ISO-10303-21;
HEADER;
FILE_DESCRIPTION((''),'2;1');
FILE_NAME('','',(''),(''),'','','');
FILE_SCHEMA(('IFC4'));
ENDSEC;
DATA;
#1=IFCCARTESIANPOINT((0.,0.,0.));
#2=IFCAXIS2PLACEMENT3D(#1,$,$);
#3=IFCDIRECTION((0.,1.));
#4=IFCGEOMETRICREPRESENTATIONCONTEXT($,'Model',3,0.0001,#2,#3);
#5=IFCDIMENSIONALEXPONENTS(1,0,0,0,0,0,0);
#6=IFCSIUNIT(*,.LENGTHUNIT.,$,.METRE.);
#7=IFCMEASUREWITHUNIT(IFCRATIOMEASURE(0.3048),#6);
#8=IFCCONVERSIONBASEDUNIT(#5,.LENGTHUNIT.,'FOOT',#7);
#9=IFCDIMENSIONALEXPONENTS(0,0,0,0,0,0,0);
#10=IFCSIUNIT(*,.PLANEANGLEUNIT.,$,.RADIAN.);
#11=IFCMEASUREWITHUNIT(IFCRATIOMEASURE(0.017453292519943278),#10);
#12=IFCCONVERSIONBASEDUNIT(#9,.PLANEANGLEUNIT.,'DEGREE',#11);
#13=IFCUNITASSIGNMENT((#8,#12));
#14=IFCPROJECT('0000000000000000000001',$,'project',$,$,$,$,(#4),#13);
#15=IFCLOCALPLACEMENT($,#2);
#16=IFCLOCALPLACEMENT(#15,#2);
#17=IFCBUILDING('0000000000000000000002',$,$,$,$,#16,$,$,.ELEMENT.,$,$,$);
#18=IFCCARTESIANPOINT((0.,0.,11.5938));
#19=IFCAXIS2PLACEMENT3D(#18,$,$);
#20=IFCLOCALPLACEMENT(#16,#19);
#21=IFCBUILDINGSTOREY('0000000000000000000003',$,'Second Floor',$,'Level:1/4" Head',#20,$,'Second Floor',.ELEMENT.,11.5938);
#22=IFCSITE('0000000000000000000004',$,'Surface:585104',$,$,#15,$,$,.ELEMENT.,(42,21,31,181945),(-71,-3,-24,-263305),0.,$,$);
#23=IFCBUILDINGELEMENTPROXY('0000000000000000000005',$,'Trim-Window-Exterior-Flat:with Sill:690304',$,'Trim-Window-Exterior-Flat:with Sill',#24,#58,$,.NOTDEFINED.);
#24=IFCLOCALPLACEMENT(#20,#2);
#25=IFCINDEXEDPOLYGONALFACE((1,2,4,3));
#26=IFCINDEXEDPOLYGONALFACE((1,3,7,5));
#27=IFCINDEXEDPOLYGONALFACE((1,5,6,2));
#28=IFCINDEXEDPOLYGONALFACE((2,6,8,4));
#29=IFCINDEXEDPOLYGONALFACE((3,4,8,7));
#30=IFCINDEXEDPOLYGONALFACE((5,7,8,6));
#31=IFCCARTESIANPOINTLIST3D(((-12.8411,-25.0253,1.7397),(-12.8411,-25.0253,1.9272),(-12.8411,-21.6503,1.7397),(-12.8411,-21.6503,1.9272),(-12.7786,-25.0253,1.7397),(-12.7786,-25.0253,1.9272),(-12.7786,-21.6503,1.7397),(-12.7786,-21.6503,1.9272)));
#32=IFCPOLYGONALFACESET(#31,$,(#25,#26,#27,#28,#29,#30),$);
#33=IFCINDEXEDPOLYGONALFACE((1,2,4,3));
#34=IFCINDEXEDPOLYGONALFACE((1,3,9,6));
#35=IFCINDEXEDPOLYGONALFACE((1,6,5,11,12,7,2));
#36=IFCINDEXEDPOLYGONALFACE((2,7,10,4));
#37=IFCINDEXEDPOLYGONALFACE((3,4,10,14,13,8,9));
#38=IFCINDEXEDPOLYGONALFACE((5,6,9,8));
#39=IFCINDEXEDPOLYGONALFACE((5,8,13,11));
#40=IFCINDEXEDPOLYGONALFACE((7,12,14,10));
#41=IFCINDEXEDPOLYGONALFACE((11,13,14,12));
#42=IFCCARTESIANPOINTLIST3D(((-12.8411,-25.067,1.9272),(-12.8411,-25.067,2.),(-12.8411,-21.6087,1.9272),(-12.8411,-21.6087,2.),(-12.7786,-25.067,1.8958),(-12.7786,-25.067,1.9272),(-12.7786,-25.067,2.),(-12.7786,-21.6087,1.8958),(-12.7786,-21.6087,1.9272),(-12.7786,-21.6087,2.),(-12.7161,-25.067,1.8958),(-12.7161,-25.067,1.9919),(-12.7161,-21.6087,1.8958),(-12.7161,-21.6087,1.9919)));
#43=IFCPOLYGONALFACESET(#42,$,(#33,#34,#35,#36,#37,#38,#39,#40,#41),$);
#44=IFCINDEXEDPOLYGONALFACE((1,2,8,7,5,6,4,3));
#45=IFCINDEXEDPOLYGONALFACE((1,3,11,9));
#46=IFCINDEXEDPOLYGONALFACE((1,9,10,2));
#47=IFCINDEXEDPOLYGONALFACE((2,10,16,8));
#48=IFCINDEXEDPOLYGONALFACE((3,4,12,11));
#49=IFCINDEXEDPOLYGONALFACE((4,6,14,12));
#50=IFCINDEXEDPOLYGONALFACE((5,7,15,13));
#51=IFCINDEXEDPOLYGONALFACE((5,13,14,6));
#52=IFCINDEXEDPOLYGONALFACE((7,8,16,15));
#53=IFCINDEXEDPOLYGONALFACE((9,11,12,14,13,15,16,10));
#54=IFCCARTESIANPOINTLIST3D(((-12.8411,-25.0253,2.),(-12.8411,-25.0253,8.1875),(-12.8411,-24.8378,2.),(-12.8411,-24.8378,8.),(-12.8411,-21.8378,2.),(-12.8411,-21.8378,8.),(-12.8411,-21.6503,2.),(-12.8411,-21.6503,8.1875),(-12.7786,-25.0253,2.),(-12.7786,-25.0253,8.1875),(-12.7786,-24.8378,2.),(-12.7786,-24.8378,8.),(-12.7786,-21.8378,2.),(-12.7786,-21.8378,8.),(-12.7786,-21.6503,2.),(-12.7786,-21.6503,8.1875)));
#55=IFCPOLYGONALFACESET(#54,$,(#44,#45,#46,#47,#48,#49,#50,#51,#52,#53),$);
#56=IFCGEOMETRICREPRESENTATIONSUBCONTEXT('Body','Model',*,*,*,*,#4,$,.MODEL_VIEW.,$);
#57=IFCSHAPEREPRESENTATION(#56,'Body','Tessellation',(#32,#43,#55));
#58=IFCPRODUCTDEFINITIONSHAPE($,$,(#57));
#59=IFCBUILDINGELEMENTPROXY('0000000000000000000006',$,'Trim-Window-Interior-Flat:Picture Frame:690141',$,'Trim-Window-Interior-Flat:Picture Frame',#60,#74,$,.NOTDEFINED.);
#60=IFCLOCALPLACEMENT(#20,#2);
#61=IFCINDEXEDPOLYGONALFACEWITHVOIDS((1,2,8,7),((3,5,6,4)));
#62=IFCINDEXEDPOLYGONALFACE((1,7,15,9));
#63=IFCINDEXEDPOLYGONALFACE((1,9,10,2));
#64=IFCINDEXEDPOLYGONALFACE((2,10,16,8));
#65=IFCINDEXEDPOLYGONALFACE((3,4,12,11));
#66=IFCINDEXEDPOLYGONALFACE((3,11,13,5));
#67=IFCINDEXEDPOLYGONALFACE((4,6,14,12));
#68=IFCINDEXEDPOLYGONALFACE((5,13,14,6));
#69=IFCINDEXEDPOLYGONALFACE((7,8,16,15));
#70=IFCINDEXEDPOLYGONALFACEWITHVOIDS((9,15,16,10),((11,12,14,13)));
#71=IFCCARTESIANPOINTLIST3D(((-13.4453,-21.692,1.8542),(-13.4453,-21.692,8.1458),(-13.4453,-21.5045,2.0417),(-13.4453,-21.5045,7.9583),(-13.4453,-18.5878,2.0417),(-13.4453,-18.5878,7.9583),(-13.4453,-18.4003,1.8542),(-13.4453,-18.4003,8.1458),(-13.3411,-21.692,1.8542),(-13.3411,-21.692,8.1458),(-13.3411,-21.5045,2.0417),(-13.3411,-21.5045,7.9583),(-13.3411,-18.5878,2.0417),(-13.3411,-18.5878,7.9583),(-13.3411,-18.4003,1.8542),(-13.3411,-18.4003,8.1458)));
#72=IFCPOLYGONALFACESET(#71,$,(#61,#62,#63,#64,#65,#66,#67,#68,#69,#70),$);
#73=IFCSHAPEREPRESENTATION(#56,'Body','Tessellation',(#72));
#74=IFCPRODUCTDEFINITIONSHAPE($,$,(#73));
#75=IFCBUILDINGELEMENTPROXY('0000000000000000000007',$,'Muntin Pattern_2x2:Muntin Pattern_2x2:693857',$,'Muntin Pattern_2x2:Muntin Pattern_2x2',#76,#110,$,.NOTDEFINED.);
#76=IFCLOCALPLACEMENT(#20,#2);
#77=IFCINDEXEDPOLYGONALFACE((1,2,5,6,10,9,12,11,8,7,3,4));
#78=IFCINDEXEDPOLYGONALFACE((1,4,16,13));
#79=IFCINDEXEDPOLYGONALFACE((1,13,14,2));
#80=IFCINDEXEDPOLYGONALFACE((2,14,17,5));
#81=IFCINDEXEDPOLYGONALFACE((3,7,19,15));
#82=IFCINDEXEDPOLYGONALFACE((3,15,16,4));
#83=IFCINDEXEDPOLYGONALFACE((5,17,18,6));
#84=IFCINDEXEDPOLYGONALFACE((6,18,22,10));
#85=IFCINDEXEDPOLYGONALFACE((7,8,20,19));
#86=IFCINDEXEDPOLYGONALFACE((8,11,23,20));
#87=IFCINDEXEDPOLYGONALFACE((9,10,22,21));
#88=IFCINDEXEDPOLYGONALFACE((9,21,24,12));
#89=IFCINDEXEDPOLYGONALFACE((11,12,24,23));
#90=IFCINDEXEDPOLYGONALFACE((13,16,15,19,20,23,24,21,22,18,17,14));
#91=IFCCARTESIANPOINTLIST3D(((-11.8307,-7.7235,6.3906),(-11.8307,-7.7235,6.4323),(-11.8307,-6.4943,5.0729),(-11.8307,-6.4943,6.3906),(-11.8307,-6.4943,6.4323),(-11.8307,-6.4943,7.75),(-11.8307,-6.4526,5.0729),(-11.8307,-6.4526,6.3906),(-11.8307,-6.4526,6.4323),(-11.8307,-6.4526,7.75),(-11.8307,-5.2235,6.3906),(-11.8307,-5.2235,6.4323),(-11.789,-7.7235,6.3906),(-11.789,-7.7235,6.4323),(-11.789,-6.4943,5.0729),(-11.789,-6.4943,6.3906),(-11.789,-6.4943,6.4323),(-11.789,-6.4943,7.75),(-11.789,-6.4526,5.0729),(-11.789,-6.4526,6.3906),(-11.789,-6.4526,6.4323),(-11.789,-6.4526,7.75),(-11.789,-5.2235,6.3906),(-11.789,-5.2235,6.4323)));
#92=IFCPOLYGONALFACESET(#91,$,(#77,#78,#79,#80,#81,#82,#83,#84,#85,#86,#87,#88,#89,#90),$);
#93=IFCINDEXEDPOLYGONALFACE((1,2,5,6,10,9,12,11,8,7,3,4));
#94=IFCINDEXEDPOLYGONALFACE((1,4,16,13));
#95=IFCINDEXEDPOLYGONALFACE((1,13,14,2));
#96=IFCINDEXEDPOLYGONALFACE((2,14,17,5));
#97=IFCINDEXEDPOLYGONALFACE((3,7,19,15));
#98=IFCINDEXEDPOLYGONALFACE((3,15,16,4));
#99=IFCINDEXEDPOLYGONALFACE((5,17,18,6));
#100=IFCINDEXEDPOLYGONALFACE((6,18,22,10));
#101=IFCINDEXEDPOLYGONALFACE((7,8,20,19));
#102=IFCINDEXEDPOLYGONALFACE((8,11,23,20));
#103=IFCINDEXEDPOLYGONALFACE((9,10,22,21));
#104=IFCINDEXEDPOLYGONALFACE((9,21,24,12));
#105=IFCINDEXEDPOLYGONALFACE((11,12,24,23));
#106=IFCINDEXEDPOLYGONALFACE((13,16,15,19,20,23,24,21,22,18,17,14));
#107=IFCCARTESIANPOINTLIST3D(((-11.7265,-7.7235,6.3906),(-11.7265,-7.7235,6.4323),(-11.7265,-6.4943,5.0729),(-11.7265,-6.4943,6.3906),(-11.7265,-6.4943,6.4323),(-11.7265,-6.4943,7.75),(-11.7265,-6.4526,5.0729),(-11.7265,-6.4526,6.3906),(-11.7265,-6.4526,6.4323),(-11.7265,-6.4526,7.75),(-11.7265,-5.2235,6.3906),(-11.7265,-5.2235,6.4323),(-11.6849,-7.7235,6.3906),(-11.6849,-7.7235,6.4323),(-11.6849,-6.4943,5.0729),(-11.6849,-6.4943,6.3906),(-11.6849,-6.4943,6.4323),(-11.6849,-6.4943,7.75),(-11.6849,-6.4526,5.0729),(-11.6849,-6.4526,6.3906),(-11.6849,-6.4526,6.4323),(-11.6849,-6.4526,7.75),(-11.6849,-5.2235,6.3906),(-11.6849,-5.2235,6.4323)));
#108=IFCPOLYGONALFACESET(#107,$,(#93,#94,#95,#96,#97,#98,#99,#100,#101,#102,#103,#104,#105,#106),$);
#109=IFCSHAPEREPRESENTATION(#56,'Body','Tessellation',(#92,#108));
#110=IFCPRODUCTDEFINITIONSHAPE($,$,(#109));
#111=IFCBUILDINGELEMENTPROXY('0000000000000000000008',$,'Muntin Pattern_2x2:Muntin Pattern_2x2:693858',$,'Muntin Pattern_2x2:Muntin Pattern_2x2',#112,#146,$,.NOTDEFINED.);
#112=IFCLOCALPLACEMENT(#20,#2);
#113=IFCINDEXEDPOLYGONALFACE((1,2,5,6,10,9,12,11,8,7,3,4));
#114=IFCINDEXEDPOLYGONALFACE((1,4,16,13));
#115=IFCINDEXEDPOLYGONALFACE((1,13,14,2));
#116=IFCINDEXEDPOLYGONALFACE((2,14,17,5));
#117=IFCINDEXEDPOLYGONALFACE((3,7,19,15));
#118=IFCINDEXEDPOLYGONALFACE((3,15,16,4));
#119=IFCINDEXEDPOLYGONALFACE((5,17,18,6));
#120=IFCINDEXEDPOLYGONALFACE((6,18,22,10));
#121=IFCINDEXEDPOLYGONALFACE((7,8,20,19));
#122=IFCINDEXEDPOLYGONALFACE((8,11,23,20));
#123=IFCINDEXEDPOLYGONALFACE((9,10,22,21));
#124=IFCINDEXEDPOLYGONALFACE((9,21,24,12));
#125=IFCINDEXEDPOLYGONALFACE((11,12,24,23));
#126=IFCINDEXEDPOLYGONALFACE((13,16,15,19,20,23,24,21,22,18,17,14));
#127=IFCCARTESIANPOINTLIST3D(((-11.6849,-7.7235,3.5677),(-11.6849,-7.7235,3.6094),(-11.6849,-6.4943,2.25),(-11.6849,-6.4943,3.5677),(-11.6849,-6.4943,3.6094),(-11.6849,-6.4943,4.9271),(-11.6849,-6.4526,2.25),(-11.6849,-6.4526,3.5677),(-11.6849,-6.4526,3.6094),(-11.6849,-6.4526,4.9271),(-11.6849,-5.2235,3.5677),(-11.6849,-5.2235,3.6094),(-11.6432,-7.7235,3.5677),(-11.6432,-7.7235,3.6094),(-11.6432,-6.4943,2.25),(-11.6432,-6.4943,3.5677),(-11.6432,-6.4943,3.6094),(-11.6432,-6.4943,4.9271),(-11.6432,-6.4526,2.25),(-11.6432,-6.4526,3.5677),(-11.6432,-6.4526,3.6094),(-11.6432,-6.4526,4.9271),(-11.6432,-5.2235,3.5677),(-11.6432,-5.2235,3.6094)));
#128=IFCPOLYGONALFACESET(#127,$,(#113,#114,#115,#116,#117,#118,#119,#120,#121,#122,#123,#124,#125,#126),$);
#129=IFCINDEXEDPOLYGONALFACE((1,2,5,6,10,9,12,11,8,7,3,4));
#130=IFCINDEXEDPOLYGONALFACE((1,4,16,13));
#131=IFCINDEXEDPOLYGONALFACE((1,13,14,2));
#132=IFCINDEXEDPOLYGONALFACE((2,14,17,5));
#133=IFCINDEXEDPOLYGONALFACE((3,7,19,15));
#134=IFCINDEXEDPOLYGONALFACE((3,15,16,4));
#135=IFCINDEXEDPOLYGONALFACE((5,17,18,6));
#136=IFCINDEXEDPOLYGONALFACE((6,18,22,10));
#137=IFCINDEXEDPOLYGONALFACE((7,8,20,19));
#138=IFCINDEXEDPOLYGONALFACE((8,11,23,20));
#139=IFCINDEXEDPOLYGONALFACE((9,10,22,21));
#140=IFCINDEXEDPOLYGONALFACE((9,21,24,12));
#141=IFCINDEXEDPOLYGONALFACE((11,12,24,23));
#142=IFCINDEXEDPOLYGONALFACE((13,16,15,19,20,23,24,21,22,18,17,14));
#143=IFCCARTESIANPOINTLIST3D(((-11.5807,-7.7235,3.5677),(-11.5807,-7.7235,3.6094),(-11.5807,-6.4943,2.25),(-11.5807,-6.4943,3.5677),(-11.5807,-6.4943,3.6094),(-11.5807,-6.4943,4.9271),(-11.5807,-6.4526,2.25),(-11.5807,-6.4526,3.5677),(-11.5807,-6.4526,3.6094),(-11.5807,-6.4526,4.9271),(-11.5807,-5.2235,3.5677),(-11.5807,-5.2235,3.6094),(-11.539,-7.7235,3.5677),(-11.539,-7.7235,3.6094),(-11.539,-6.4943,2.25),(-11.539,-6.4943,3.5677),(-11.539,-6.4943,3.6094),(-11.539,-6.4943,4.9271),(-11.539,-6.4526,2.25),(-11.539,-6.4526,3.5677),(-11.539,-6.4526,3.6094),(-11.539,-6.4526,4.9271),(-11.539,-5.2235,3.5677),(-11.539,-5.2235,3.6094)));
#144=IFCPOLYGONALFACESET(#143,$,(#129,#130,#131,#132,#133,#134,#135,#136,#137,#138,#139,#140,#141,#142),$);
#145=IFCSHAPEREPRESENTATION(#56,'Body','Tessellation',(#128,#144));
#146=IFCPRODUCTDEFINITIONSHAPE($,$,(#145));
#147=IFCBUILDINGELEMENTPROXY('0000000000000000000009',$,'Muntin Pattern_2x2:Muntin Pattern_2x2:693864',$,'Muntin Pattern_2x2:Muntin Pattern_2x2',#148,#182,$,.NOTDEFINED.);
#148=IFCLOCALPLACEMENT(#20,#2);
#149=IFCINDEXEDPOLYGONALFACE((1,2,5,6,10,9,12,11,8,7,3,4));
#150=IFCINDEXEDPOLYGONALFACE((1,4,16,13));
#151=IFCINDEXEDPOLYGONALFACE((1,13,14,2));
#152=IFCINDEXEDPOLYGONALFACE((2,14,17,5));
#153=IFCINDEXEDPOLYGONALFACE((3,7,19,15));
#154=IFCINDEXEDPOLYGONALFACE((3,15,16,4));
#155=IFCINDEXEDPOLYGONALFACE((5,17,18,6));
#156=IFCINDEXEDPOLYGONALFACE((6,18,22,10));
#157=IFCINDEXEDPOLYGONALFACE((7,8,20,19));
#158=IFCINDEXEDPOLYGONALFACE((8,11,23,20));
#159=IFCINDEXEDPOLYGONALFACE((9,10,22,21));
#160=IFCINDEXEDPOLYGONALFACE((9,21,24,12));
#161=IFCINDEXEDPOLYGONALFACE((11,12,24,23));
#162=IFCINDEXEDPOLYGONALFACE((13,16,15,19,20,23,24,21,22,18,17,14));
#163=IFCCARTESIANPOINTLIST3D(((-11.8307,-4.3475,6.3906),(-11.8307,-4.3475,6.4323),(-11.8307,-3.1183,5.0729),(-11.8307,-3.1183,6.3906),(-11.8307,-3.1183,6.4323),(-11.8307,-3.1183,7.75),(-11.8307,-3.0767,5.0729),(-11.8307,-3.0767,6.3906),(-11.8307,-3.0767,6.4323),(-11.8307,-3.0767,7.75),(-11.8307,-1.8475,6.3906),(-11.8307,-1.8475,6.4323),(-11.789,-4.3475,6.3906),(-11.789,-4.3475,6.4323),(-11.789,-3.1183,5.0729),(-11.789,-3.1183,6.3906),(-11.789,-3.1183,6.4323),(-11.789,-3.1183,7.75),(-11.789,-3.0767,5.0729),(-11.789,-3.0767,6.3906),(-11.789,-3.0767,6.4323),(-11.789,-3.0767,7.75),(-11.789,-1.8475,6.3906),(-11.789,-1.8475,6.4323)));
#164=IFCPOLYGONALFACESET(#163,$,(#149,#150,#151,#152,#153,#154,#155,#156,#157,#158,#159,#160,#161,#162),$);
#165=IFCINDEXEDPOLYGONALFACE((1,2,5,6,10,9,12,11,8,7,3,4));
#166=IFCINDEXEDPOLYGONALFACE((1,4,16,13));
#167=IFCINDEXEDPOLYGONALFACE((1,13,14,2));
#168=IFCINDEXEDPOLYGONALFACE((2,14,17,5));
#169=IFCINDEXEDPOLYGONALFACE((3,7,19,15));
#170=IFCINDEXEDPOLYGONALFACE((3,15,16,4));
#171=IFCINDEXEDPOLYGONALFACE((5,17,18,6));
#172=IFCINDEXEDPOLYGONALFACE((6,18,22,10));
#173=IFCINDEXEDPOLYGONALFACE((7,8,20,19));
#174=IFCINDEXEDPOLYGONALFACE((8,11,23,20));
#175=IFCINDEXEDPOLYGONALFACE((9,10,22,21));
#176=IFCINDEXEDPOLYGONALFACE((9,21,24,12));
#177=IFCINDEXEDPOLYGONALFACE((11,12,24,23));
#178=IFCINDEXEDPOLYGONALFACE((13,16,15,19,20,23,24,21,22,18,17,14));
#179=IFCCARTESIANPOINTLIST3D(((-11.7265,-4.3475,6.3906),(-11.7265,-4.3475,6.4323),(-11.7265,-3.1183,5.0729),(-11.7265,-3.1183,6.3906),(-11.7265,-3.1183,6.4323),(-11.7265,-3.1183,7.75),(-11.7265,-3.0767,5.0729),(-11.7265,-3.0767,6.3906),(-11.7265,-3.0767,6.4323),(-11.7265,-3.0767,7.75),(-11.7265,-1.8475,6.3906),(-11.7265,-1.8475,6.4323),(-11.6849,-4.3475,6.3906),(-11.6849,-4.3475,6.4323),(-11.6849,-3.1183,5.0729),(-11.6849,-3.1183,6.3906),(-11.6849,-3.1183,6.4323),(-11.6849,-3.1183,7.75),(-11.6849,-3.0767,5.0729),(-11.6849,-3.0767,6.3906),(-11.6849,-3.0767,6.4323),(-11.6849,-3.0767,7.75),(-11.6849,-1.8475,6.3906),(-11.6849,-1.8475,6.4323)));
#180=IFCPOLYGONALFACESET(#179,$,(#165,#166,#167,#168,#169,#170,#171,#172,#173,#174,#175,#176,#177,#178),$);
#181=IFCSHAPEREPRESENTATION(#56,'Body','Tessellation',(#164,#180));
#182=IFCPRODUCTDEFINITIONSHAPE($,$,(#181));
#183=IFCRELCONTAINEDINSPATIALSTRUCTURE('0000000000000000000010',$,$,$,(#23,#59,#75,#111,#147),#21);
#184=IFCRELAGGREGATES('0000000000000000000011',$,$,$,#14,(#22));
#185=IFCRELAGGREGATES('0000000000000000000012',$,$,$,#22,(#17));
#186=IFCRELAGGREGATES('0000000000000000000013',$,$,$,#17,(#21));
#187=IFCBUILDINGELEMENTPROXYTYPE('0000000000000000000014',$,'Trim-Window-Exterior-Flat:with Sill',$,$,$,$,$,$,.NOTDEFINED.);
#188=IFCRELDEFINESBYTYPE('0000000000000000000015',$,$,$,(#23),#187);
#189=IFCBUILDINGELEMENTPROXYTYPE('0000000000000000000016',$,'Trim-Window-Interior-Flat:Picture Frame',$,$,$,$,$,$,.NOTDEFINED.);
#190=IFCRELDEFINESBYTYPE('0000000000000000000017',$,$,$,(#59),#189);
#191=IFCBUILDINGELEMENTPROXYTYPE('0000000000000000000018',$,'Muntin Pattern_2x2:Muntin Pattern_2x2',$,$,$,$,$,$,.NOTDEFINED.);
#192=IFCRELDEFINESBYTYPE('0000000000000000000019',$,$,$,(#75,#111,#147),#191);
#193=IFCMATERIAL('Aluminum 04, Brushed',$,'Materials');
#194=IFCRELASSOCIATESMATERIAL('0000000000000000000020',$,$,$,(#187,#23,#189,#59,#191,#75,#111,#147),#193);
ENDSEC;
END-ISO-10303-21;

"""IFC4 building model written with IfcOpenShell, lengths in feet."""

from ifc_helpers import new_model, entity, si_unit, converted_unit, direction, frame, origin, place, context, subcontext, project, spatial, indexed_curve, outline, extrude, source, transform, mapped, material, type_object, type_shapes, element, save


model = new_model("IFC4")

# Units and contexts
model_context = context("Model", 3, precision=0.0001, world=origin(), true_north=direction((0.0, 1.0)))
body_context = subcontext(model_context, "Body", "Model", "MODEL_VIEW")
ifc_project = project(units=[converted_unit("LENGTHUNIT", "FOOT", entity("IfcRatioMeasure", 0.3048), si_unit("LENGTHUNIT", "METRE"), dimensions=[1, 0, 0, 0, 0, 0, 0]), converted_unit("PLANEANGLEUNIT", "DEGREE", entity("IfcRatioMeasure", 0.017453292519943278), si_unit("PLANEANGLEUNIT", "RADIAN"), dimensions=[0, 0, 0, 0, 0, 0, 0])], contexts=[model_context])

# Site, building, storey
site_placement = place(None, origin())
site = spatial("IfcSite", under=ifc_project, at=site_placement, Name="Surface:585104", CompositionType="ELEMENT", RefLatitude=(42, 21, 31, 181945), RefLongitude=(-71, -3, -24, -263305), RefElevation=0.0)
building_placement = place(site_placement, origin())
building = spatial("IfcBuilding", under=site, at=building_placement, CompositionType="ELEMENT")
storey_placement = place(building_placement, frame((0.0, 0.0, 11.5938)))
storey = spatial("IfcBuildingStorey", under=building, at=storey_placement, Name="Second Floor", ObjectType="Level:1/4\" Head", LongName="Second Floor", CompositionType="ELEMENT", Elevation=11.5938)

# Shared definitions
ifc_material_1 = material(Name="Aluminum 04, Brushed", Category="Materials")

# Building element proxies
building_element_proxy_type_1 = type_object("IfcBuildingElementProxyType", Name="Trim-Window-Exterior-Flat:with Sill", PredefinedType="NOTDEFINED", material=ifc_material_1)
shared_shape_1 = source(origin(), body_context, "Body", "SweptSolid", [
    extrude(outline(indexed_curve([(-0.0938, -1.6875), (0.0938, -1.6875), (0.0938, 1.6875), (-0.0938, 1.6875), (-0.0938, -1.6875)], self_intersect=False)), frame((0.0, 6.1665, 0.0), z_axis=(0.0, 0.0, 1.0), x_axis=(0.0, 1.0, 0.0)), (0.0, 0.0, 1.0), 0.0625),
    extrude(outline(indexed_curve([(-0.0525, -0.0625), (0.0436, -0.0625), (0.0517, 0.0), (0.0517, 0.0625), (-0.0211, 0.0625), (-0.0211, 0.0), (-0.0525, 0.0), (-0.0525, -0.0625)], self_intersect=False)), frame((-1.7292, 6.0517, 0.0625), z_axis=(1.0, 0.0, 0.0), x_axis=(0.0, -1.0, 0.0)), (0.0, 0.0, 1.0), 3.4583),
    extrude(outline(indexed_curve([(-1.6875, -3.1406), (1.6875, -3.1406), (1.6875, 3.0469), (1.5, 3.0469), (1.5, -2.9531), (-1.5, -2.9531), (-1.5, 3.0469), (-1.6875, 3.0469), (-1.6875, -3.1406)], self_intersect=False)), frame((0.0, 2.9531, 0.0)), (0.0, 0.0, 1.0), 0.0625),
])
type_shapes(building_element_proxy_type_1, [shared_shape_1])
for number, where, z_axis, x_axis, name in (
    (1, (-12.8411, -23.3378, 8.0), (1.0, 0.0, 0.0), (0.0, -1.0, 0.0), "Trim-Window-Exterior-Flat:with Sill:690304"),
):
    element("IfcBuildingElementProxy", number, at=place(storey_placement, frame(where, z_axis=z_axis, x_axis=x_axis)), inside=storey, type_object=building_element_proxy_type_1, material=ifc_material_1, Name=name, ObjectType="Trim-Window-Exterior-Flat:with Sill", PredefinedType="NOTDEFINED", context=body_context, shape_type="MappedRepresentation", body=[
        mapped(shared_shape_1, transform((0.0, 0.0, 0.0), scale=1.0)),
    ])
building_element_proxy_type_2 = type_object("IfcBuildingElementProxyType", Name="Trim-Window-Interior-Flat:Picture Frame", PredefinedType="NOTDEFINED", material=ifc_material_1)
shared_shape_2 = source(origin(), body_context, "Body", "SweptSolid", [
    extrude(outline(indexed_curve([(-3.1458, -1.6458), (3.1458, -1.6458), (3.1458, 1.6458), (-3.1458, 1.6458), (-3.1458, -1.6458)], self_intersect=False), holes=[indexed_curve([(-2.9583, -1.4583), (-2.9583, 1.4583), (2.9583, 1.4583), (2.9583, -1.4583), (-2.9583, -1.4583)], self_intersect=False)]), frame((0.0, 3.0, 0.0), z_axis=(0.0, 0.0, 1.0), x_axis=(0.0, 1.0, 0.0)), (0.0, 0.0, 1.0), 0.1042),
])
type_shapes(building_element_proxy_type_2, [shared_shape_2])
proxy_placement = place(storey_placement, frame((-13.3411, -20.0462, 8.0), z_axis=(-1.0, 0.0, 0.0), x_axis=(0.0, 1.0, 0.0)))
element("IfcBuildingElementProxy", 2, at=proxy_placement, inside=storey, type_object=building_element_proxy_type_2, material=ifc_material_1, Name="Trim-Window-Interior-Flat:Picture Frame:690141", ObjectType="Trim-Window-Interior-Flat:Picture Frame", PredefinedType="NOTDEFINED", context=body_context, shape_type="MappedRepresentation", body=[
    mapped(shared_shape_2, transform((0.0, 0.0, 0.0), scale=1.0)),
])
building_element_proxy_type_3 = type_object("IfcBuildingElementProxyType", Name="Muntin Pattern_2x2:Muntin Pattern_2x2", PredefinedType="NOTDEFINED", material=ifc_material_1)
shared_shape_3 = source(origin(), body_context, "Body", "SweptSolid", [
    extrude(outline(indexed_curve([(0.0208, -0.0208), (1.3385, -0.0208), (1.3385, 0.0208), (0.0208, 0.0208), (0.0208, 1.25), (-0.0208, 1.25), (-0.0208, 0.0208), (-1.3385, 0.0208), (-1.3385, -0.0208), (-0.0208, -0.0208), (-0.0208, -1.25), (0.0208, -1.25), (0.0208, -0.0208)], self_intersect=False)), frame((0.0, 0.0312, 1.3385), z_axis=(0.0, 1.0, 0.0), x_axis=(0.0, 0.0, 1.0)), (0.0, 0.0, 1.0), 0.0417),
    extrude(outline(indexed_curve([(0.0208, -0.0208), (1.3385, -0.0208), (1.3385, 0.0208), (0.0208, 0.0208), (0.0208, 1.25), (-0.0208, 1.25), (-0.0208, 0.0208), (-1.3385, 0.0208), (-1.3385, -0.0208), (-0.0208, -0.0208), (-0.0208, -1.25), (0.0208, -1.25), (0.0208, -0.0208)], self_intersect=False)), frame((0.0, -0.0729, 1.3385), z_axis=(0.0, 1.0, 0.0), x_axis=(0.0, 0.0, 1.0)), (0.0, 0.0, 1.0), 0.0417),
])
type_shapes(building_element_proxy_type_3, [shared_shape_3])
for number, where, z_axis, x_axis, name in (
    (3, (-11.7578, -6.4735, 5.0729), (0.0, 0.0, 1.0), (0.0, 1.0, 0.0), "Muntin Pattern_2x2:Muntin Pattern_2x2:693857"),
    (4, (-11.612, -6.4735, 2.25), (0.0, 0.0, 1.0), (0.0, 1.0, 0.0), "Muntin Pattern_2x2:Muntin Pattern_2x2:693858"),
    (5, (-11.7578, -3.0975, 5.0729), (0.0, 0.0, 1.0), (0.0, 1.0, 0.0), "Muntin Pattern_2x2:Muntin Pattern_2x2:693864"),
):
    element("IfcBuildingElementProxy", number, at=place(storey_placement, frame(where, z_axis=z_axis, x_axis=x_axis)), inside=storey, type_object=building_element_proxy_type_3, material=ifc_material_1, Name=name, ObjectType="Muntin Pattern_2x2:Muntin Pattern_2x2", PredefinedType="NOTDEFINED", context=body_context, shape_type="MappedRepresentation", body=[
        mapped(shared_shape_3, transform((0.0, 0.0, 0.0), scale=1.0)),
    ])

save(model, "model.ifc")
